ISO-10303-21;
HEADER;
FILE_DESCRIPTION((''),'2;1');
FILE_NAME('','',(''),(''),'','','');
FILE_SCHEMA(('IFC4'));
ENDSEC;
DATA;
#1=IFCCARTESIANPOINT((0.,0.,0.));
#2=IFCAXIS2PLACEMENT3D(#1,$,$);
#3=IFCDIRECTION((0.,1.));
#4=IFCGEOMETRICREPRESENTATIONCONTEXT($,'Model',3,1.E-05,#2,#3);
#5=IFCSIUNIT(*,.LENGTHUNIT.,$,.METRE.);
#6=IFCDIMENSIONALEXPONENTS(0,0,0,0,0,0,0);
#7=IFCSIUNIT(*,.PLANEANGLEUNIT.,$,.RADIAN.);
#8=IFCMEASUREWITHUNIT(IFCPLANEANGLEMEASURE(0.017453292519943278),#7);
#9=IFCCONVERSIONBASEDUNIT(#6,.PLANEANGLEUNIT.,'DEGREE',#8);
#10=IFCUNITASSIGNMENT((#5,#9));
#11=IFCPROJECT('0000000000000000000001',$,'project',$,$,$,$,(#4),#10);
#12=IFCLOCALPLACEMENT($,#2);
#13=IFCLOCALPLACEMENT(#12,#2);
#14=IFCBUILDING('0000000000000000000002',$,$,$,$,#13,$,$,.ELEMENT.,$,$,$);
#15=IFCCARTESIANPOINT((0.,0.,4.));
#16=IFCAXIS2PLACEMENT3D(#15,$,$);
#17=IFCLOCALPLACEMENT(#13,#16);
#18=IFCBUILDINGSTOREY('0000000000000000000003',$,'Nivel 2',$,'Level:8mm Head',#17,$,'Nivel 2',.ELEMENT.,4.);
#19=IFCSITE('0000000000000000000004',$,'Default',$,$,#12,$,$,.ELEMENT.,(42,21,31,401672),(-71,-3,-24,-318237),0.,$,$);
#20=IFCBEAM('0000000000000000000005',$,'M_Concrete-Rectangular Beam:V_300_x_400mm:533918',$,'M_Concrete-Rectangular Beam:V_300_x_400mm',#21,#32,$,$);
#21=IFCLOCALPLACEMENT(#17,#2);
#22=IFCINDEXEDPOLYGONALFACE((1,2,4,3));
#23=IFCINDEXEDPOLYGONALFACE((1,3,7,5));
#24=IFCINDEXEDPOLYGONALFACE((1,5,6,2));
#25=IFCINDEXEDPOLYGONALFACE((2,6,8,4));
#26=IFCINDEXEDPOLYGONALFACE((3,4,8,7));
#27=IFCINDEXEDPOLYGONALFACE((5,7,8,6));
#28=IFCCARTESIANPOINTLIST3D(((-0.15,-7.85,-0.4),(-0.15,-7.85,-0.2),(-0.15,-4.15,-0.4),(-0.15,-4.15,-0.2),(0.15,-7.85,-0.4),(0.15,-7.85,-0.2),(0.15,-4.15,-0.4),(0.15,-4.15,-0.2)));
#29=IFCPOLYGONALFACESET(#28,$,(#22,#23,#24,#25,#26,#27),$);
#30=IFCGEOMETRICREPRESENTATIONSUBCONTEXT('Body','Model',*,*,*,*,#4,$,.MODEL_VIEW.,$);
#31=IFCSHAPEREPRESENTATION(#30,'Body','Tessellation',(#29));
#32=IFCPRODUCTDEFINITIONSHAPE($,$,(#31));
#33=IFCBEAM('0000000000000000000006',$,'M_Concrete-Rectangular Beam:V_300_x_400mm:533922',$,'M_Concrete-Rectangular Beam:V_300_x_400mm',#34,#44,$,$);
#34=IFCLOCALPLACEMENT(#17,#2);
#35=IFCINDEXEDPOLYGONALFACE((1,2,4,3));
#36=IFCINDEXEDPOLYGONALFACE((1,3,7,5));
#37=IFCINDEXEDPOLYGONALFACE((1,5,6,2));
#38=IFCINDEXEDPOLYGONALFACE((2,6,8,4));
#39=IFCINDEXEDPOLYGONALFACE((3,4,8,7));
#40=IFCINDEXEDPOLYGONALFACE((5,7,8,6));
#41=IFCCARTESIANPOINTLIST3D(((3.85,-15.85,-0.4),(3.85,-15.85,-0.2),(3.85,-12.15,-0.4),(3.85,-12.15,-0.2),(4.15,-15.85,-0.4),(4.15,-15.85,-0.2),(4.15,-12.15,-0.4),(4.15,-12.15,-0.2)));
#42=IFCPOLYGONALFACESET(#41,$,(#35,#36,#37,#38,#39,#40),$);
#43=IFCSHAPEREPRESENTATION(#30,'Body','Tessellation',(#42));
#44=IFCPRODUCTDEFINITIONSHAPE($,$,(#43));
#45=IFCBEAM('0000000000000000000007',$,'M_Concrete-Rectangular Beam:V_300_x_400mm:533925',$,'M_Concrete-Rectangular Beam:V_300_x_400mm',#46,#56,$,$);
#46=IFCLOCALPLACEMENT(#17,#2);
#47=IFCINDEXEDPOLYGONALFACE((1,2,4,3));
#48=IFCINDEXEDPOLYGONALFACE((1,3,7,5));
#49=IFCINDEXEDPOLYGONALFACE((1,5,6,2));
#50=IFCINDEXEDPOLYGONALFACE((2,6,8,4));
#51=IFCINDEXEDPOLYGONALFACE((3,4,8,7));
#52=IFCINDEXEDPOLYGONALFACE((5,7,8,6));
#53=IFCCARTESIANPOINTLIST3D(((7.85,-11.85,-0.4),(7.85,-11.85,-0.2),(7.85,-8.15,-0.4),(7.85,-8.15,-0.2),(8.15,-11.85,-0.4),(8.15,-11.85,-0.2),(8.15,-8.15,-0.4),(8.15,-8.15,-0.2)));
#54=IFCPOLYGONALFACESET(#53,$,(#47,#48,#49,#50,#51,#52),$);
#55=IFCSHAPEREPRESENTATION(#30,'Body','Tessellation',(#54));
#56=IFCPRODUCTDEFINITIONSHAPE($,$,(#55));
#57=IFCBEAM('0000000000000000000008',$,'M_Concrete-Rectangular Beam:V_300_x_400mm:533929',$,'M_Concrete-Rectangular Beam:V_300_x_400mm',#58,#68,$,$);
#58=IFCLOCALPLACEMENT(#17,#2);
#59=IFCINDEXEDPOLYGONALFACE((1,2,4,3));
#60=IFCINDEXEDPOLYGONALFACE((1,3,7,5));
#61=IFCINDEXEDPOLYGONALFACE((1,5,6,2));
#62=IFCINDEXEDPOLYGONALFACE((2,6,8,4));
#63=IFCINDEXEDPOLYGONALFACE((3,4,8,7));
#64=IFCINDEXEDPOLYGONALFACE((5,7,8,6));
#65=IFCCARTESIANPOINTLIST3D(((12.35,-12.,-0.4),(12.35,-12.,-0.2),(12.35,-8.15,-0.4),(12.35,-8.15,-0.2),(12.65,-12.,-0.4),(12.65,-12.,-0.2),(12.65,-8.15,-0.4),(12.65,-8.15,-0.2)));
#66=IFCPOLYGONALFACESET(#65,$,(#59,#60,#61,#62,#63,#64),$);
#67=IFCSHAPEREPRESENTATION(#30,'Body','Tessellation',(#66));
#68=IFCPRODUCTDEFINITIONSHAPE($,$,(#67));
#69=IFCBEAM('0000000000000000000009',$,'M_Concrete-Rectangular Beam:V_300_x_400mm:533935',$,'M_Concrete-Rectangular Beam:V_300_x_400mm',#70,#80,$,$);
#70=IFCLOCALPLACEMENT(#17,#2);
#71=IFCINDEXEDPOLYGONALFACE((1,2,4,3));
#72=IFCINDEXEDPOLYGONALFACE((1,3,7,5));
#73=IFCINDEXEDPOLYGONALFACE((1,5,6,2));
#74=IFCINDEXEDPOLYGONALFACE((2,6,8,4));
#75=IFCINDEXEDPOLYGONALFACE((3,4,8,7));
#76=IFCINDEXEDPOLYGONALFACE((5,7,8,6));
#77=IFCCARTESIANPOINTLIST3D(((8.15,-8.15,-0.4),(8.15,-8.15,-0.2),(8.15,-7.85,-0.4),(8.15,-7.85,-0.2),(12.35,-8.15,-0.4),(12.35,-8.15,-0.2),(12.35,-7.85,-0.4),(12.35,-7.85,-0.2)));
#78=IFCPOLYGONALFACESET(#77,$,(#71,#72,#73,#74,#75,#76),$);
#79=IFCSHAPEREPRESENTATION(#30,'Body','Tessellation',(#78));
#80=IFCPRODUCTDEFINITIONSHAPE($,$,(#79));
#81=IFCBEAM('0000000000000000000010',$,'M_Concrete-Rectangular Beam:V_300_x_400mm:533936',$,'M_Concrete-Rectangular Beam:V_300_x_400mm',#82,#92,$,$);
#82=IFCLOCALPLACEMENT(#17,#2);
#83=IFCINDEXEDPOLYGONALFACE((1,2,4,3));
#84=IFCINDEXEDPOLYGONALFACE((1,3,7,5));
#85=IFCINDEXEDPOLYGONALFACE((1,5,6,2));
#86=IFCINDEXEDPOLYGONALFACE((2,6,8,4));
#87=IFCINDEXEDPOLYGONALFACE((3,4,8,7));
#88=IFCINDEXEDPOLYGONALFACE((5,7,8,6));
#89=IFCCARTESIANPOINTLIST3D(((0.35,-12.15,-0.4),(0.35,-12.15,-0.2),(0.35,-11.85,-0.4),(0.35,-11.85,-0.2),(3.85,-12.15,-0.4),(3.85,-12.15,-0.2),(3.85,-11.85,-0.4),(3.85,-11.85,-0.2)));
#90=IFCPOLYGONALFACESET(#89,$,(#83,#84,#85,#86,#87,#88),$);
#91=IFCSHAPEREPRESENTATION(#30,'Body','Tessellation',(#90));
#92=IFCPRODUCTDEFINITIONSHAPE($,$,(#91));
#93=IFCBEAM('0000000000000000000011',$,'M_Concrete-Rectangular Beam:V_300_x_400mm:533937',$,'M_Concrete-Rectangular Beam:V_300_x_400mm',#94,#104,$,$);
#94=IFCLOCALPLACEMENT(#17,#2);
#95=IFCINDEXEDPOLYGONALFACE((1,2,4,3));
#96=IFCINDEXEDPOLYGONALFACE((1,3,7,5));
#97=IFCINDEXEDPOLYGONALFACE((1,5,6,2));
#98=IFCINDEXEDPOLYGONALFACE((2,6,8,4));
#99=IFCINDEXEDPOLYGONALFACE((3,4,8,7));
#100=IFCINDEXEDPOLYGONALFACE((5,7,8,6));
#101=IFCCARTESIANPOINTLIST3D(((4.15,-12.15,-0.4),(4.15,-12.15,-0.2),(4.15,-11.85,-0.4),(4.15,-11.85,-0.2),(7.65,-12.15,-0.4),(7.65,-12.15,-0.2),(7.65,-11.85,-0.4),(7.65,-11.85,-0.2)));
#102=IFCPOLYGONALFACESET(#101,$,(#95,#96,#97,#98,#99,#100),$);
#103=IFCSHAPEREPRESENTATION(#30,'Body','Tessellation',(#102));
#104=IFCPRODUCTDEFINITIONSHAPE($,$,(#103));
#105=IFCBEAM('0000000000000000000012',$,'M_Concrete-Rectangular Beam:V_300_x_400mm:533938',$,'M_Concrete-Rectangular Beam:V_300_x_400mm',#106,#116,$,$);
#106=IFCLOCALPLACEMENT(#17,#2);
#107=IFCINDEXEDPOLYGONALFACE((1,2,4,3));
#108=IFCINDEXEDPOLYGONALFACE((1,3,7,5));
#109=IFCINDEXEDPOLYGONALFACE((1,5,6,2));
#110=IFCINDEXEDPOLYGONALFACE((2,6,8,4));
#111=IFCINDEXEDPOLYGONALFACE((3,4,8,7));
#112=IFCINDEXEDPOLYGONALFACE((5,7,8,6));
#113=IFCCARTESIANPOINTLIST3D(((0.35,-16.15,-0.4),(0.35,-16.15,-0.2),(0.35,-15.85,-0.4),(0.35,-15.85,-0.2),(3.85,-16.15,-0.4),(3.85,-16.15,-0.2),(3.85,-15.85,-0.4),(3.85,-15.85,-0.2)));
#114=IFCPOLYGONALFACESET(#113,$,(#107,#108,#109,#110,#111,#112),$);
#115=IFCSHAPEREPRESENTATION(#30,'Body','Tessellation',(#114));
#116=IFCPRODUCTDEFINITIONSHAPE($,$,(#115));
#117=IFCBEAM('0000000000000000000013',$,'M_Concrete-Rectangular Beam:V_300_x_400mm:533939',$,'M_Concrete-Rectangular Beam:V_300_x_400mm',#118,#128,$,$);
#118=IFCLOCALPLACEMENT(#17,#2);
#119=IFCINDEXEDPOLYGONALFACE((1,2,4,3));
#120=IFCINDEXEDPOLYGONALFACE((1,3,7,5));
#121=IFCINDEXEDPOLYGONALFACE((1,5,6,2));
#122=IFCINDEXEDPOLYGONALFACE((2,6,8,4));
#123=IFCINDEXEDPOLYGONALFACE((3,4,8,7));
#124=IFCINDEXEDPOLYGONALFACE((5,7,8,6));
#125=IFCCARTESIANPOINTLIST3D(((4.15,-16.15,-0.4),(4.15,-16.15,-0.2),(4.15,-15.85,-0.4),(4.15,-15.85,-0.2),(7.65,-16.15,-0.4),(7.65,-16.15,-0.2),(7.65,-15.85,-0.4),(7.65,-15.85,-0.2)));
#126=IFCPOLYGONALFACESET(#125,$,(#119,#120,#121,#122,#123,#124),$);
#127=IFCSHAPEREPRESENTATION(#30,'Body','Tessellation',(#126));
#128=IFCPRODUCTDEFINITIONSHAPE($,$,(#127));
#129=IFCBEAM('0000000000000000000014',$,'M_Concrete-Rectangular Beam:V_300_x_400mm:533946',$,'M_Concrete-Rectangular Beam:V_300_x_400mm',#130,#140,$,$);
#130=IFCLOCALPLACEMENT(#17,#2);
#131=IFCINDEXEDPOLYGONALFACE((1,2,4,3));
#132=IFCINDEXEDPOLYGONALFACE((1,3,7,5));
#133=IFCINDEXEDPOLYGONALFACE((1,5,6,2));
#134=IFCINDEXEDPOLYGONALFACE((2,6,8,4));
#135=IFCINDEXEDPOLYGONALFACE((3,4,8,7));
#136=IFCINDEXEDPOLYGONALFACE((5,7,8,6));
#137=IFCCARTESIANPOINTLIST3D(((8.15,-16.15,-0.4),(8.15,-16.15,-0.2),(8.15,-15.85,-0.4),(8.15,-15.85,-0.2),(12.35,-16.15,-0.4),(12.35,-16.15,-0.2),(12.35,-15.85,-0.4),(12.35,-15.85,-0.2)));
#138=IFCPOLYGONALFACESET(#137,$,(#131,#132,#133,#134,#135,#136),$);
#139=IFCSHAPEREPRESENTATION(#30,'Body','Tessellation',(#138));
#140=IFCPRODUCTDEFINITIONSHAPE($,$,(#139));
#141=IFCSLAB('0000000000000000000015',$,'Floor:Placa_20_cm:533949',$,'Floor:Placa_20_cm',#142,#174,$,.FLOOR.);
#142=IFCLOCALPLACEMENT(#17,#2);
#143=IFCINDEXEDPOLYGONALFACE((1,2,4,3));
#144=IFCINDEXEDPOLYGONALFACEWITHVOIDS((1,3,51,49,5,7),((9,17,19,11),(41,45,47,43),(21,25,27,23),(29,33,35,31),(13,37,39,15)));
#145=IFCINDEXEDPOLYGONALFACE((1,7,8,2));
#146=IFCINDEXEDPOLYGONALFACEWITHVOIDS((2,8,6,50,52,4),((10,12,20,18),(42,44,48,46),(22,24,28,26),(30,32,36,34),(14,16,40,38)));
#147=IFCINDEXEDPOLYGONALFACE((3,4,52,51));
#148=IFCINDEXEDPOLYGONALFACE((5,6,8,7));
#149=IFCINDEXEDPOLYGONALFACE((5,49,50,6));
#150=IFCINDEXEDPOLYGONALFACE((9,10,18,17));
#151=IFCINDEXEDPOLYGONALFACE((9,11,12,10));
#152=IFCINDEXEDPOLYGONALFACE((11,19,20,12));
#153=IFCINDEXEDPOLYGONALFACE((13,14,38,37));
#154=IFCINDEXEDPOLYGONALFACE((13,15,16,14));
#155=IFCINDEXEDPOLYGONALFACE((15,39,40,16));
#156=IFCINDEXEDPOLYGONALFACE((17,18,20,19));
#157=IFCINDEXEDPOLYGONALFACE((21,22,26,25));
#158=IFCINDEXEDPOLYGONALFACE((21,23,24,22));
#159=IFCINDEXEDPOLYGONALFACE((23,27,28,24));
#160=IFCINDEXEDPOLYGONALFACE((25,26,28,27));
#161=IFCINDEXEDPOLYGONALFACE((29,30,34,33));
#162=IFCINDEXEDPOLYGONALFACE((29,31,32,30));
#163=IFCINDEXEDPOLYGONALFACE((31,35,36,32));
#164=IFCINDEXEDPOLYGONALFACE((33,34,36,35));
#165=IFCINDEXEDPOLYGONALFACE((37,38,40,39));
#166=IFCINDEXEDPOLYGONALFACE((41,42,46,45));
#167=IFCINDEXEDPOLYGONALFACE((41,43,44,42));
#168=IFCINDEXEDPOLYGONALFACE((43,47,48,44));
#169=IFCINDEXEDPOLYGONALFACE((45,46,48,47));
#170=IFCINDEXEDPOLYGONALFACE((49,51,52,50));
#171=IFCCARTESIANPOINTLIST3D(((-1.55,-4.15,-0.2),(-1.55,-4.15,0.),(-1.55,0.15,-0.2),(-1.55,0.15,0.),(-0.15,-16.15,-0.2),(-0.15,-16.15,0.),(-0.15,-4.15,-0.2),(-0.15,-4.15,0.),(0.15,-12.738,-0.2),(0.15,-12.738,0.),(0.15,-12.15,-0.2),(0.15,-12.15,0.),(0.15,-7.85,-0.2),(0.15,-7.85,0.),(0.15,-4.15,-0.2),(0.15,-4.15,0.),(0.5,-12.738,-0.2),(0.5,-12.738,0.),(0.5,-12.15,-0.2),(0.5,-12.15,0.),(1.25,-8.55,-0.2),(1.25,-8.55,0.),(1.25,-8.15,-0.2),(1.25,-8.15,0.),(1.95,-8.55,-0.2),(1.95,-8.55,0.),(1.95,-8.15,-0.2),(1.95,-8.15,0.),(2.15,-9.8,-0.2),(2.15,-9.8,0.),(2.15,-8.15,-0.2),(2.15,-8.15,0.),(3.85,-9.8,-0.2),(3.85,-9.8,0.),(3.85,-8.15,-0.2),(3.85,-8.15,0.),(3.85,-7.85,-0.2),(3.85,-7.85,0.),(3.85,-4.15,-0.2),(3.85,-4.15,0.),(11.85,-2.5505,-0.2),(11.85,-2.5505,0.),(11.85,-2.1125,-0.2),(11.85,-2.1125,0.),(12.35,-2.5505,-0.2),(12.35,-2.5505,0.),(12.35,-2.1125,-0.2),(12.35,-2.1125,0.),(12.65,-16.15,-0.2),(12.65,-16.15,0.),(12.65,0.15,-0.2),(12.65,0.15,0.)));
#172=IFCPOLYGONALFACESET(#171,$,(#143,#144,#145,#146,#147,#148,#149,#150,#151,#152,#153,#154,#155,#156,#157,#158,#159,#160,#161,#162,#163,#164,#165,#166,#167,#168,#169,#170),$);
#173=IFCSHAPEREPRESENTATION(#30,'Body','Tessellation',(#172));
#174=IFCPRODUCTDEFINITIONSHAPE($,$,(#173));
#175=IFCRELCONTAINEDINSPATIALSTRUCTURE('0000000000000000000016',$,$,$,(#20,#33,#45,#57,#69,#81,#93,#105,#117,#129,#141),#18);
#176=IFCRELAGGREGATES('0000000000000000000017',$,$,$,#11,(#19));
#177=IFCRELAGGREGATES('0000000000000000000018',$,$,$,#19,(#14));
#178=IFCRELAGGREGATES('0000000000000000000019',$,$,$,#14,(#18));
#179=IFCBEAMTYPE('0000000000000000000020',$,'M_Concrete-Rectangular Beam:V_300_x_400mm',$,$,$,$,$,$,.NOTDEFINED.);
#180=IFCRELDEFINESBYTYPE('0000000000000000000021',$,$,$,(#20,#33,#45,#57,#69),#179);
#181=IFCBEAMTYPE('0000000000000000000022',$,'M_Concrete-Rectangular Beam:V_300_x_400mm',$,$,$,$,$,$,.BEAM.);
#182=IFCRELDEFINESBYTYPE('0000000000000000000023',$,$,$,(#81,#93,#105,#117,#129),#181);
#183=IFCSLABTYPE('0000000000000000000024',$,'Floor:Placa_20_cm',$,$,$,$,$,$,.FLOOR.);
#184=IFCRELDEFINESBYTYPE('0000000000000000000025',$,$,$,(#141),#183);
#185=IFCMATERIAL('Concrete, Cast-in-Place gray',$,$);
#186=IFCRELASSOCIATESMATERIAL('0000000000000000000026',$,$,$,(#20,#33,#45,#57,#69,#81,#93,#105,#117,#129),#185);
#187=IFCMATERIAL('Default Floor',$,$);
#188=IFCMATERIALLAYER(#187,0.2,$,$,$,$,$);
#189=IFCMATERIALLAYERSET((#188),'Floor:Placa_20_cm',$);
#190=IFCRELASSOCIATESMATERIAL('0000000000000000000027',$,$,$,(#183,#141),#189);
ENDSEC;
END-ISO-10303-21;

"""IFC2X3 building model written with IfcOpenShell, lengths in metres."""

from ifc_helpers import new_model, entity, si_unit, converted_unit, direction, frame, frame_2d, origin, place, context, subcontext, project, spatial, polyline, rectangle, outline, extrude, material, layer, layer_set, layer_usage, type_object, element, save


model = new_model("IFC2X3")

# Units and contexts
model_context = context("Model", 3, precision=1e-05, world=origin(), true_north=direction((0.0, 1.0)))
body_context = subcontext(model_context, "Body", "Model", "MODEL_VIEW")
ifc_project = project(units=[si_unit("LENGTHUNIT", "METRE"), converted_unit("PLANEANGLEUNIT", "DEGREE", entity("IfcPlaneAngleMeasure", 0.017453292519943278), si_unit("PLANEANGLEUNIT", "RADIAN"), dimensions=[0, 0, 0, 0, 0, 0, 0])], contexts=[model_context])

# Site, building, storey
site_placement = place(None, origin())
site = spatial("IfcSite", under=ifc_project, at=site_placement, Name="Default", CompositionType="ELEMENT", RefLatitude=(42, 21, 31, 401672), RefLongitude=(-71, -3, -24, -318237), RefElevation=0.0)
building_placement = place(site_placement, origin())
building = spatial("IfcBuilding", under=site, at=building_placement, CompositionType="ELEMENT")
storey_placement = place(building_placement, frame((0.0, 0.0, 4.0)))
storey = spatial("IfcBuildingStorey", under=building, at=storey_placement, Name="Nivel 2", ObjectType="Level:8mm Head", LongName="Nivel 2", CompositionType="ELEMENT", Elevation=4.0)

# Beams
ifc_material_1 = material(Name="Concrete, Cast-in-Place gray")
beam_type_1 = type_object("IfcBeamType", Name="M_Concrete-Rectangular Beam:V_300_x_400mm", PredefinedType="NOTDEFINED")
beam_1_placement = place(storey_placement, frame((0.0, -8.0, 0.0), z_axis=(0.0, 0.0, 1.0), x_axis=(0.0, 1.0, 0.0)))
element("IfcBeam", 1, at=beam_1_placement, inside=storey, type_object=beam_type_1, material=ifc_material_1, Name="M_Concrete-Rectangular Beam:V_300_x_400mm:533918", ObjectType="M_Concrete-Rectangular Beam:V_300_x_400mm", context=body_context, shape_type="SweptSolid", body=[
    extrude(rectangle(XDim=0.2, YDim=0.3, at=frame_2d((0.0, 0.0), x_axis=(1.0, 0.0))), frame((0.15, 0.0, -0.3), z_axis=(1.0, 0.0, 0.0), x_axis=(0.0, 0.0, -1.0)), (0.0, 0.0, 1.0), 3.7),
])
beam_2_placement = place(storey_placement, frame((4.0, -12.0, 0.0), z_axis=(0.0, 0.0, 1.0), x_axis=(0.0, -1.0, 0.0)))
element("IfcBeam", 2, at=beam_2_placement, inside=storey, type_object=beam_type_1, material=ifc_material_1, Name="M_Concrete-Rectangular Beam:V_300_x_400mm:533922", ObjectType="M_Concrete-Rectangular Beam:V_300_x_400mm", context=body_context, shape_type="SweptSolid", body=[
    extrude(rectangle(XDim=0.2, YDim=0.3, at=frame_2d((0.0, 0.0), x_axis=(1.0, 0.0))), frame((0.15, 0.0, -0.3), z_axis=(1.0, 0.0, 0.0), x_axis=(0.0, 0.0, -1.0)), (0.0, 0.0, 1.0), 3.7),
])
beam_3_placement = place(storey_placement, frame((8.0, -8.0, 0.0), z_axis=(0.0, 0.0, 1.0), x_axis=(0.0, -1.0, 0.0)))
element("IfcBeam", 3, at=beam_3_placement, inside=storey, type_object=beam_type_1, material=ifc_material_1, Name="M_Concrete-Rectangular Beam:V_300_x_400mm:533925", ObjectType="M_Concrete-Rectangular Beam:V_300_x_400mm", context=body_context, shape_type="SweptSolid", body=[
    extrude(rectangle(XDim=0.2, YDim=0.3, at=frame_2d((0.0, 0.0), x_axis=(1.0, 0.0))), frame((0.15, 0.0, -0.3), z_axis=(1.0, 0.0, 0.0), x_axis=(0.0, 0.0, -1.0)), (0.0, 0.0, 1.0), 3.7),
])
beam_4_placement = place(storey_placement, frame((12.5, -8.0, 0.0), z_axis=(0.0, 0.0, 1.0), x_axis=(0.0, -1.0, 0.0)))
element("IfcBeam", 4, at=beam_4_placement, inside=storey, type_object=beam_type_1, material=ifc_material_1, Name="M_Concrete-Rectangular Beam:V_300_x_400mm:533929", ObjectType="M_Concrete-Rectangular Beam:V_300_x_400mm", context=body_context, shape_type="SweptSolid", body=[
    extrude(rectangle(XDim=0.2, YDim=0.3, at=frame_2d((0.0, 0.0), x_axis=(1.0, 0.0))), frame((0.15, 0.0, -0.3), z_axis=(1.0, 0.0, 0.0), x_axis=(0.0, 0.0, -1.0)), (0.0, 0.0, 1.0), 3.85),
])
beam_5_placement = place(storey_placement, frame((8.0, -8.0, 0.0)))
element("IfcBeam", 5, at=beam_5_placement, inside=storey, type_object=beam_type_1, material=ifc_material_1, Name="M_Concrete-Rectangular Beam:V_300_x_400mm:533935", ObjectType="M_Concrete-Rectangular Beam:V_300_x_400mm", context=body_context, shape_type="SweptSolid", body=[
    extrude(rectangle(XDim=0.2, YDim=0.3, at=frame_2d((0.0, 0.0), x_axis=(1.0, 0.0))), frame((0.15, 0.0, -0.3), z_axis=(1.0, 0.0, 0.0), x_axis=(0.0, 0.0, -1.0)), (0.0, 0.0, 1.0), 4.2),
])
beam_type_2 = type_object("IfcBeamType", Name="M_Concrete-Rectangular Beam:V_300_x_400mm", PredefinedType="BEAM")
beam_6_placement = place(storey_placement, frame((0.35, -12.0, 0.0)))
element("IfcBeam", 6, at=beam_6_placement, inside=storey, type_object=beam_type_2, material=ifc_material_1, Name="M_Concrete-Rectangular Beam:V_300_x_400mm:533936", ObjectType="M_Concrete-Rectangular Beam:V_300_x_400mm", context=body_context, shape_type="SweptSolid", body=[
    extrude(rectangle(XDim=0.2, YDim=0.3, at=frame_2d((0.0, 0.0), x_axis=(1.0, 0.0))), frame((0.0, 0.0, -0.3), z_axis=(1.0, 0.0, 0.0), x_axis=(0.0, 0.0, -1.0)), (0.0, 0.0, 1.0), 3.5),
])
beam_7_placement = place(storey_placement, frame((4.0, -12.0, 0.0)))
element("IfcBeam", 7, at=beam_7_placement, inside=storey, type_object=beam_type_2, material=ifc_material_1, Name="M_Concrete-Rectangular Beam:V_300_x_400mm:533937", ObjectType="M_Concrete-Rectangular Beam:V_300_x_400mm", context=body_context, shape_type="SweptSolid", body=[
    extrude(rectangle(XDim=0.2, YDim=0.3, at=frame_2d((0.0, 0.0), x_axis=(1.0, 0.0))), frame((0.15, 0.0, -0.3), z_axis=(1.0, 0.0, 0.0), x_axis=(0.0, 0.0, -1.0)), (0.0, 0.0, 1.0), 3.5),
])
beam_8_placement = place(storey_placement, frame((0.35, -16.0, 0.0)))
element("IfcBeam", 8, at=beam_8_placement, inside=storey, type_object=beam_type_2, material=ifc_material_1, Name="M_Concrete-Rectangular Beam:V_300_x_400mm:533938", ObjectType="M_Concrete-Rectangular Beam:V_300_x_400mm", context=body_context, shape_type="SweptSolid", body=[
    extrude(rectangle(XDim=0.2, YDim=0.3, at=frame_2d((0.0, 0.0), x_axis=(1.0, 0.0))), frame((0.0, 0.0, -0.3), z_axis=(1.0, 0.0, 0.0), x_axis=(0.0, 0.0, -1.0)), (0.0, 0.0, 1.0), 3.5),
])
beam_9_placement = place(storey_placement, frame((4.0, -16.0, 0.0)))
element("IfcBeam", 9, at=beam_9_placement, inside=storey, type_object=beam_type_2, material=ifc_material_1, Name="M_Concrete-Rectangular Beam:V_300_x_400mm:533939", ObjectType="M_Concrete-Rectangular Beam:V_300_x_400mm", context=body_context, shape_type="SweptSolid", body=[
    extrude(rectangle(XDim=0.2, YDim=0.3, at=frame_2d((0.0, 0.0), x_axis=(1.0, 0.0))), frame((0.15, 0.0, -0.3), z_axis=(1.0, 0.0, 0.0), x_axis=(0.0, 0.0, -1.0)), (0.0, 0.0, 1.0), 3.5),
])
beam_10_placement = place(storey_placement, frame((8.05, -16.0, 0.0)))
element("IfcBeam", 10, at=beam_10_placement, inside=storey, type_object=beam_type_2, material=ifc_material_1, Name="M_Concrete-Rectangular Beam:V_300_x_400mm:533946", ObjectType="M_Concrete-Rectangular Beam:V_300_x_400mm", context=body_context, shape_type="SweptSolid", body=[
    extrude(rectangle(XDim=0.2, YDim=0.3, at=frame_2d((0.0, 0.0), x_axis=(1.0, 0.0))), frame((0.1, 0.0, -0.3), z_axis=(1.0, 0.0, 0.0), x_axis=(0.0, 0.0, -1.0)), (0.0, 0.0, 1.0), 4.2),
])

# Slab, openings
ifc_material_2 = material(Name="Default Floor")
ifc_layer_1 = layer(ifc_material_2, 0.2)
ifc_layer_set_1 = layer_set([ifc_layer_1], Name="Floor:Placa_20_cm")
ifc_layer_usage_1 = layer_usage(ifc_layer_set_1, "AXIS3", "POSITIVE", 0.0)
slab_type = type_object("IfcSlabType", Name="Floor:Placa_20_cm", PredefinedType="FLOOR", material=ifc_layer_set_1)
slab_placement = place(storey_placement, frame((-1.55, -16.15, -0.2)))
slab = element("IfcSlab", 11, at=slab_placement, inside=storey, type_object=slab_type, material=ifc_layer_usage_1, Name="Floor:Placa_20_cm:533949", ObjectType="Floor:Placa_20_cm", PredefinedType="FLOOR", context=body_context, shape_type="SweptSolid", body=[
    extrude(outline(polyline([(-7.1, 8.15), (-7.1, -8.15), (5.7, -8.15), (5.7, 3.85), (7.1, 3.85), (7.1, 8.15), (-7.1, 8.15)])), frame((7.1, 8.15, 0.2), z_axis=(0.0, 0.0, -1.0), x_axis=(-1.0, 0.0, 0.0)), (0.0, 0.0, 1.0), 0.2),
])
opening_1_placement = place(slab_placement, origin())
element("IfcOpeningElement", 12, at=opening_1_placement, cuts=slab, ObjectType="Opening", context=body_context, shape_type="SweptSolid", body=[
    extrude(rectangle(XDim=3.7, YDim=3.7, at=frame_2d((3.55, 2.0), x_axis=(0.0, -1.0))), frame((7.1, 8.15, 0.2), z_axis=(0.0, 0.0, -1.0), x_axis=(-1.0, 0.0, 0.0)), (0.0, 0.0, 1.0), 0.2),
])
opening_2_placement = place(slab_placement, origin())
element("IfcOpeningElement", 13, at=opening_2_placement, cuts=slab, ObjectType="Opening", context=body_context, shape_type="SweptSolid", body=[
    extrude(rectangle(XDim=0.438, YDim=0.5, at=frame_2d((-6.55, 5.6685), x_axis=(0.0, 1.0))), frame((7.1, 8.15, 0.2), z_axis=(0.0, 0.0, -1.0), x_axis=(-1.0, 0.0, 0.0)), (0.0, 0.0, 1.0), 0.2),
])
opening_3_placement = place(slab_placement, origin())
element("IfcOpeningElement", 14, at=opening_3_placement, cuts=slab, ObjectType="Opening", context=body_context, shape_type="SweptSolid", body=[
    extrude(rectangle(XDim=0.4, YDim=0.7, at=frame_2d((3.95, -0.35), x_axis=(0.0, 1.0))), frame((7.1, 8.15, 0.2), z_axis=(0.0, 0.0, -1.0), x_axis=(-1.0, 0.0, 0.0)), (0.0, 0.0, 1.0), 0.2),
])
opening_4_placement = place(slab_placement, origin())
element("IfcOpeningElement", 15, at=opening_4_placement, cuts=slab, ObjectType="Opening", context=body_context, shape_type="SweptSolid", body=[
    extrude(rectangle(XDim=0.588, YDim=0.35, at=frame_2d((5.225, -4.444), x_axis=(0.0, 1.0))), frame((7.1, 8.15, 0.2), z_axis=(0.0, 0.0, -1.0), x_axis=(-1.0, 0.0, 0.0)), (0.0, 0.0, 1.0), 0.2),
])
opening_5_placement = place(slab_placement, origin())
element("IfcOpeningElement", 16, at=opening_5_placement, cuts=slab, ObjectType="Opening", context=body_context, shape_type="SweptSolid", body=[
    extrude(rectangle(XDim=1.65, YDim=1.7, at=frame_2d((2.55, -0.975), x_axis=(0.0, 1.0))), frame((7.1, 8.15, 0.2), z_axis=(0.0, 0.0, -1.0), x_axis=(-1.0, 0.0, 0.0)), (0.0, 0.0, 1.0), 0.2),
])

save(model, "model.ifc")
